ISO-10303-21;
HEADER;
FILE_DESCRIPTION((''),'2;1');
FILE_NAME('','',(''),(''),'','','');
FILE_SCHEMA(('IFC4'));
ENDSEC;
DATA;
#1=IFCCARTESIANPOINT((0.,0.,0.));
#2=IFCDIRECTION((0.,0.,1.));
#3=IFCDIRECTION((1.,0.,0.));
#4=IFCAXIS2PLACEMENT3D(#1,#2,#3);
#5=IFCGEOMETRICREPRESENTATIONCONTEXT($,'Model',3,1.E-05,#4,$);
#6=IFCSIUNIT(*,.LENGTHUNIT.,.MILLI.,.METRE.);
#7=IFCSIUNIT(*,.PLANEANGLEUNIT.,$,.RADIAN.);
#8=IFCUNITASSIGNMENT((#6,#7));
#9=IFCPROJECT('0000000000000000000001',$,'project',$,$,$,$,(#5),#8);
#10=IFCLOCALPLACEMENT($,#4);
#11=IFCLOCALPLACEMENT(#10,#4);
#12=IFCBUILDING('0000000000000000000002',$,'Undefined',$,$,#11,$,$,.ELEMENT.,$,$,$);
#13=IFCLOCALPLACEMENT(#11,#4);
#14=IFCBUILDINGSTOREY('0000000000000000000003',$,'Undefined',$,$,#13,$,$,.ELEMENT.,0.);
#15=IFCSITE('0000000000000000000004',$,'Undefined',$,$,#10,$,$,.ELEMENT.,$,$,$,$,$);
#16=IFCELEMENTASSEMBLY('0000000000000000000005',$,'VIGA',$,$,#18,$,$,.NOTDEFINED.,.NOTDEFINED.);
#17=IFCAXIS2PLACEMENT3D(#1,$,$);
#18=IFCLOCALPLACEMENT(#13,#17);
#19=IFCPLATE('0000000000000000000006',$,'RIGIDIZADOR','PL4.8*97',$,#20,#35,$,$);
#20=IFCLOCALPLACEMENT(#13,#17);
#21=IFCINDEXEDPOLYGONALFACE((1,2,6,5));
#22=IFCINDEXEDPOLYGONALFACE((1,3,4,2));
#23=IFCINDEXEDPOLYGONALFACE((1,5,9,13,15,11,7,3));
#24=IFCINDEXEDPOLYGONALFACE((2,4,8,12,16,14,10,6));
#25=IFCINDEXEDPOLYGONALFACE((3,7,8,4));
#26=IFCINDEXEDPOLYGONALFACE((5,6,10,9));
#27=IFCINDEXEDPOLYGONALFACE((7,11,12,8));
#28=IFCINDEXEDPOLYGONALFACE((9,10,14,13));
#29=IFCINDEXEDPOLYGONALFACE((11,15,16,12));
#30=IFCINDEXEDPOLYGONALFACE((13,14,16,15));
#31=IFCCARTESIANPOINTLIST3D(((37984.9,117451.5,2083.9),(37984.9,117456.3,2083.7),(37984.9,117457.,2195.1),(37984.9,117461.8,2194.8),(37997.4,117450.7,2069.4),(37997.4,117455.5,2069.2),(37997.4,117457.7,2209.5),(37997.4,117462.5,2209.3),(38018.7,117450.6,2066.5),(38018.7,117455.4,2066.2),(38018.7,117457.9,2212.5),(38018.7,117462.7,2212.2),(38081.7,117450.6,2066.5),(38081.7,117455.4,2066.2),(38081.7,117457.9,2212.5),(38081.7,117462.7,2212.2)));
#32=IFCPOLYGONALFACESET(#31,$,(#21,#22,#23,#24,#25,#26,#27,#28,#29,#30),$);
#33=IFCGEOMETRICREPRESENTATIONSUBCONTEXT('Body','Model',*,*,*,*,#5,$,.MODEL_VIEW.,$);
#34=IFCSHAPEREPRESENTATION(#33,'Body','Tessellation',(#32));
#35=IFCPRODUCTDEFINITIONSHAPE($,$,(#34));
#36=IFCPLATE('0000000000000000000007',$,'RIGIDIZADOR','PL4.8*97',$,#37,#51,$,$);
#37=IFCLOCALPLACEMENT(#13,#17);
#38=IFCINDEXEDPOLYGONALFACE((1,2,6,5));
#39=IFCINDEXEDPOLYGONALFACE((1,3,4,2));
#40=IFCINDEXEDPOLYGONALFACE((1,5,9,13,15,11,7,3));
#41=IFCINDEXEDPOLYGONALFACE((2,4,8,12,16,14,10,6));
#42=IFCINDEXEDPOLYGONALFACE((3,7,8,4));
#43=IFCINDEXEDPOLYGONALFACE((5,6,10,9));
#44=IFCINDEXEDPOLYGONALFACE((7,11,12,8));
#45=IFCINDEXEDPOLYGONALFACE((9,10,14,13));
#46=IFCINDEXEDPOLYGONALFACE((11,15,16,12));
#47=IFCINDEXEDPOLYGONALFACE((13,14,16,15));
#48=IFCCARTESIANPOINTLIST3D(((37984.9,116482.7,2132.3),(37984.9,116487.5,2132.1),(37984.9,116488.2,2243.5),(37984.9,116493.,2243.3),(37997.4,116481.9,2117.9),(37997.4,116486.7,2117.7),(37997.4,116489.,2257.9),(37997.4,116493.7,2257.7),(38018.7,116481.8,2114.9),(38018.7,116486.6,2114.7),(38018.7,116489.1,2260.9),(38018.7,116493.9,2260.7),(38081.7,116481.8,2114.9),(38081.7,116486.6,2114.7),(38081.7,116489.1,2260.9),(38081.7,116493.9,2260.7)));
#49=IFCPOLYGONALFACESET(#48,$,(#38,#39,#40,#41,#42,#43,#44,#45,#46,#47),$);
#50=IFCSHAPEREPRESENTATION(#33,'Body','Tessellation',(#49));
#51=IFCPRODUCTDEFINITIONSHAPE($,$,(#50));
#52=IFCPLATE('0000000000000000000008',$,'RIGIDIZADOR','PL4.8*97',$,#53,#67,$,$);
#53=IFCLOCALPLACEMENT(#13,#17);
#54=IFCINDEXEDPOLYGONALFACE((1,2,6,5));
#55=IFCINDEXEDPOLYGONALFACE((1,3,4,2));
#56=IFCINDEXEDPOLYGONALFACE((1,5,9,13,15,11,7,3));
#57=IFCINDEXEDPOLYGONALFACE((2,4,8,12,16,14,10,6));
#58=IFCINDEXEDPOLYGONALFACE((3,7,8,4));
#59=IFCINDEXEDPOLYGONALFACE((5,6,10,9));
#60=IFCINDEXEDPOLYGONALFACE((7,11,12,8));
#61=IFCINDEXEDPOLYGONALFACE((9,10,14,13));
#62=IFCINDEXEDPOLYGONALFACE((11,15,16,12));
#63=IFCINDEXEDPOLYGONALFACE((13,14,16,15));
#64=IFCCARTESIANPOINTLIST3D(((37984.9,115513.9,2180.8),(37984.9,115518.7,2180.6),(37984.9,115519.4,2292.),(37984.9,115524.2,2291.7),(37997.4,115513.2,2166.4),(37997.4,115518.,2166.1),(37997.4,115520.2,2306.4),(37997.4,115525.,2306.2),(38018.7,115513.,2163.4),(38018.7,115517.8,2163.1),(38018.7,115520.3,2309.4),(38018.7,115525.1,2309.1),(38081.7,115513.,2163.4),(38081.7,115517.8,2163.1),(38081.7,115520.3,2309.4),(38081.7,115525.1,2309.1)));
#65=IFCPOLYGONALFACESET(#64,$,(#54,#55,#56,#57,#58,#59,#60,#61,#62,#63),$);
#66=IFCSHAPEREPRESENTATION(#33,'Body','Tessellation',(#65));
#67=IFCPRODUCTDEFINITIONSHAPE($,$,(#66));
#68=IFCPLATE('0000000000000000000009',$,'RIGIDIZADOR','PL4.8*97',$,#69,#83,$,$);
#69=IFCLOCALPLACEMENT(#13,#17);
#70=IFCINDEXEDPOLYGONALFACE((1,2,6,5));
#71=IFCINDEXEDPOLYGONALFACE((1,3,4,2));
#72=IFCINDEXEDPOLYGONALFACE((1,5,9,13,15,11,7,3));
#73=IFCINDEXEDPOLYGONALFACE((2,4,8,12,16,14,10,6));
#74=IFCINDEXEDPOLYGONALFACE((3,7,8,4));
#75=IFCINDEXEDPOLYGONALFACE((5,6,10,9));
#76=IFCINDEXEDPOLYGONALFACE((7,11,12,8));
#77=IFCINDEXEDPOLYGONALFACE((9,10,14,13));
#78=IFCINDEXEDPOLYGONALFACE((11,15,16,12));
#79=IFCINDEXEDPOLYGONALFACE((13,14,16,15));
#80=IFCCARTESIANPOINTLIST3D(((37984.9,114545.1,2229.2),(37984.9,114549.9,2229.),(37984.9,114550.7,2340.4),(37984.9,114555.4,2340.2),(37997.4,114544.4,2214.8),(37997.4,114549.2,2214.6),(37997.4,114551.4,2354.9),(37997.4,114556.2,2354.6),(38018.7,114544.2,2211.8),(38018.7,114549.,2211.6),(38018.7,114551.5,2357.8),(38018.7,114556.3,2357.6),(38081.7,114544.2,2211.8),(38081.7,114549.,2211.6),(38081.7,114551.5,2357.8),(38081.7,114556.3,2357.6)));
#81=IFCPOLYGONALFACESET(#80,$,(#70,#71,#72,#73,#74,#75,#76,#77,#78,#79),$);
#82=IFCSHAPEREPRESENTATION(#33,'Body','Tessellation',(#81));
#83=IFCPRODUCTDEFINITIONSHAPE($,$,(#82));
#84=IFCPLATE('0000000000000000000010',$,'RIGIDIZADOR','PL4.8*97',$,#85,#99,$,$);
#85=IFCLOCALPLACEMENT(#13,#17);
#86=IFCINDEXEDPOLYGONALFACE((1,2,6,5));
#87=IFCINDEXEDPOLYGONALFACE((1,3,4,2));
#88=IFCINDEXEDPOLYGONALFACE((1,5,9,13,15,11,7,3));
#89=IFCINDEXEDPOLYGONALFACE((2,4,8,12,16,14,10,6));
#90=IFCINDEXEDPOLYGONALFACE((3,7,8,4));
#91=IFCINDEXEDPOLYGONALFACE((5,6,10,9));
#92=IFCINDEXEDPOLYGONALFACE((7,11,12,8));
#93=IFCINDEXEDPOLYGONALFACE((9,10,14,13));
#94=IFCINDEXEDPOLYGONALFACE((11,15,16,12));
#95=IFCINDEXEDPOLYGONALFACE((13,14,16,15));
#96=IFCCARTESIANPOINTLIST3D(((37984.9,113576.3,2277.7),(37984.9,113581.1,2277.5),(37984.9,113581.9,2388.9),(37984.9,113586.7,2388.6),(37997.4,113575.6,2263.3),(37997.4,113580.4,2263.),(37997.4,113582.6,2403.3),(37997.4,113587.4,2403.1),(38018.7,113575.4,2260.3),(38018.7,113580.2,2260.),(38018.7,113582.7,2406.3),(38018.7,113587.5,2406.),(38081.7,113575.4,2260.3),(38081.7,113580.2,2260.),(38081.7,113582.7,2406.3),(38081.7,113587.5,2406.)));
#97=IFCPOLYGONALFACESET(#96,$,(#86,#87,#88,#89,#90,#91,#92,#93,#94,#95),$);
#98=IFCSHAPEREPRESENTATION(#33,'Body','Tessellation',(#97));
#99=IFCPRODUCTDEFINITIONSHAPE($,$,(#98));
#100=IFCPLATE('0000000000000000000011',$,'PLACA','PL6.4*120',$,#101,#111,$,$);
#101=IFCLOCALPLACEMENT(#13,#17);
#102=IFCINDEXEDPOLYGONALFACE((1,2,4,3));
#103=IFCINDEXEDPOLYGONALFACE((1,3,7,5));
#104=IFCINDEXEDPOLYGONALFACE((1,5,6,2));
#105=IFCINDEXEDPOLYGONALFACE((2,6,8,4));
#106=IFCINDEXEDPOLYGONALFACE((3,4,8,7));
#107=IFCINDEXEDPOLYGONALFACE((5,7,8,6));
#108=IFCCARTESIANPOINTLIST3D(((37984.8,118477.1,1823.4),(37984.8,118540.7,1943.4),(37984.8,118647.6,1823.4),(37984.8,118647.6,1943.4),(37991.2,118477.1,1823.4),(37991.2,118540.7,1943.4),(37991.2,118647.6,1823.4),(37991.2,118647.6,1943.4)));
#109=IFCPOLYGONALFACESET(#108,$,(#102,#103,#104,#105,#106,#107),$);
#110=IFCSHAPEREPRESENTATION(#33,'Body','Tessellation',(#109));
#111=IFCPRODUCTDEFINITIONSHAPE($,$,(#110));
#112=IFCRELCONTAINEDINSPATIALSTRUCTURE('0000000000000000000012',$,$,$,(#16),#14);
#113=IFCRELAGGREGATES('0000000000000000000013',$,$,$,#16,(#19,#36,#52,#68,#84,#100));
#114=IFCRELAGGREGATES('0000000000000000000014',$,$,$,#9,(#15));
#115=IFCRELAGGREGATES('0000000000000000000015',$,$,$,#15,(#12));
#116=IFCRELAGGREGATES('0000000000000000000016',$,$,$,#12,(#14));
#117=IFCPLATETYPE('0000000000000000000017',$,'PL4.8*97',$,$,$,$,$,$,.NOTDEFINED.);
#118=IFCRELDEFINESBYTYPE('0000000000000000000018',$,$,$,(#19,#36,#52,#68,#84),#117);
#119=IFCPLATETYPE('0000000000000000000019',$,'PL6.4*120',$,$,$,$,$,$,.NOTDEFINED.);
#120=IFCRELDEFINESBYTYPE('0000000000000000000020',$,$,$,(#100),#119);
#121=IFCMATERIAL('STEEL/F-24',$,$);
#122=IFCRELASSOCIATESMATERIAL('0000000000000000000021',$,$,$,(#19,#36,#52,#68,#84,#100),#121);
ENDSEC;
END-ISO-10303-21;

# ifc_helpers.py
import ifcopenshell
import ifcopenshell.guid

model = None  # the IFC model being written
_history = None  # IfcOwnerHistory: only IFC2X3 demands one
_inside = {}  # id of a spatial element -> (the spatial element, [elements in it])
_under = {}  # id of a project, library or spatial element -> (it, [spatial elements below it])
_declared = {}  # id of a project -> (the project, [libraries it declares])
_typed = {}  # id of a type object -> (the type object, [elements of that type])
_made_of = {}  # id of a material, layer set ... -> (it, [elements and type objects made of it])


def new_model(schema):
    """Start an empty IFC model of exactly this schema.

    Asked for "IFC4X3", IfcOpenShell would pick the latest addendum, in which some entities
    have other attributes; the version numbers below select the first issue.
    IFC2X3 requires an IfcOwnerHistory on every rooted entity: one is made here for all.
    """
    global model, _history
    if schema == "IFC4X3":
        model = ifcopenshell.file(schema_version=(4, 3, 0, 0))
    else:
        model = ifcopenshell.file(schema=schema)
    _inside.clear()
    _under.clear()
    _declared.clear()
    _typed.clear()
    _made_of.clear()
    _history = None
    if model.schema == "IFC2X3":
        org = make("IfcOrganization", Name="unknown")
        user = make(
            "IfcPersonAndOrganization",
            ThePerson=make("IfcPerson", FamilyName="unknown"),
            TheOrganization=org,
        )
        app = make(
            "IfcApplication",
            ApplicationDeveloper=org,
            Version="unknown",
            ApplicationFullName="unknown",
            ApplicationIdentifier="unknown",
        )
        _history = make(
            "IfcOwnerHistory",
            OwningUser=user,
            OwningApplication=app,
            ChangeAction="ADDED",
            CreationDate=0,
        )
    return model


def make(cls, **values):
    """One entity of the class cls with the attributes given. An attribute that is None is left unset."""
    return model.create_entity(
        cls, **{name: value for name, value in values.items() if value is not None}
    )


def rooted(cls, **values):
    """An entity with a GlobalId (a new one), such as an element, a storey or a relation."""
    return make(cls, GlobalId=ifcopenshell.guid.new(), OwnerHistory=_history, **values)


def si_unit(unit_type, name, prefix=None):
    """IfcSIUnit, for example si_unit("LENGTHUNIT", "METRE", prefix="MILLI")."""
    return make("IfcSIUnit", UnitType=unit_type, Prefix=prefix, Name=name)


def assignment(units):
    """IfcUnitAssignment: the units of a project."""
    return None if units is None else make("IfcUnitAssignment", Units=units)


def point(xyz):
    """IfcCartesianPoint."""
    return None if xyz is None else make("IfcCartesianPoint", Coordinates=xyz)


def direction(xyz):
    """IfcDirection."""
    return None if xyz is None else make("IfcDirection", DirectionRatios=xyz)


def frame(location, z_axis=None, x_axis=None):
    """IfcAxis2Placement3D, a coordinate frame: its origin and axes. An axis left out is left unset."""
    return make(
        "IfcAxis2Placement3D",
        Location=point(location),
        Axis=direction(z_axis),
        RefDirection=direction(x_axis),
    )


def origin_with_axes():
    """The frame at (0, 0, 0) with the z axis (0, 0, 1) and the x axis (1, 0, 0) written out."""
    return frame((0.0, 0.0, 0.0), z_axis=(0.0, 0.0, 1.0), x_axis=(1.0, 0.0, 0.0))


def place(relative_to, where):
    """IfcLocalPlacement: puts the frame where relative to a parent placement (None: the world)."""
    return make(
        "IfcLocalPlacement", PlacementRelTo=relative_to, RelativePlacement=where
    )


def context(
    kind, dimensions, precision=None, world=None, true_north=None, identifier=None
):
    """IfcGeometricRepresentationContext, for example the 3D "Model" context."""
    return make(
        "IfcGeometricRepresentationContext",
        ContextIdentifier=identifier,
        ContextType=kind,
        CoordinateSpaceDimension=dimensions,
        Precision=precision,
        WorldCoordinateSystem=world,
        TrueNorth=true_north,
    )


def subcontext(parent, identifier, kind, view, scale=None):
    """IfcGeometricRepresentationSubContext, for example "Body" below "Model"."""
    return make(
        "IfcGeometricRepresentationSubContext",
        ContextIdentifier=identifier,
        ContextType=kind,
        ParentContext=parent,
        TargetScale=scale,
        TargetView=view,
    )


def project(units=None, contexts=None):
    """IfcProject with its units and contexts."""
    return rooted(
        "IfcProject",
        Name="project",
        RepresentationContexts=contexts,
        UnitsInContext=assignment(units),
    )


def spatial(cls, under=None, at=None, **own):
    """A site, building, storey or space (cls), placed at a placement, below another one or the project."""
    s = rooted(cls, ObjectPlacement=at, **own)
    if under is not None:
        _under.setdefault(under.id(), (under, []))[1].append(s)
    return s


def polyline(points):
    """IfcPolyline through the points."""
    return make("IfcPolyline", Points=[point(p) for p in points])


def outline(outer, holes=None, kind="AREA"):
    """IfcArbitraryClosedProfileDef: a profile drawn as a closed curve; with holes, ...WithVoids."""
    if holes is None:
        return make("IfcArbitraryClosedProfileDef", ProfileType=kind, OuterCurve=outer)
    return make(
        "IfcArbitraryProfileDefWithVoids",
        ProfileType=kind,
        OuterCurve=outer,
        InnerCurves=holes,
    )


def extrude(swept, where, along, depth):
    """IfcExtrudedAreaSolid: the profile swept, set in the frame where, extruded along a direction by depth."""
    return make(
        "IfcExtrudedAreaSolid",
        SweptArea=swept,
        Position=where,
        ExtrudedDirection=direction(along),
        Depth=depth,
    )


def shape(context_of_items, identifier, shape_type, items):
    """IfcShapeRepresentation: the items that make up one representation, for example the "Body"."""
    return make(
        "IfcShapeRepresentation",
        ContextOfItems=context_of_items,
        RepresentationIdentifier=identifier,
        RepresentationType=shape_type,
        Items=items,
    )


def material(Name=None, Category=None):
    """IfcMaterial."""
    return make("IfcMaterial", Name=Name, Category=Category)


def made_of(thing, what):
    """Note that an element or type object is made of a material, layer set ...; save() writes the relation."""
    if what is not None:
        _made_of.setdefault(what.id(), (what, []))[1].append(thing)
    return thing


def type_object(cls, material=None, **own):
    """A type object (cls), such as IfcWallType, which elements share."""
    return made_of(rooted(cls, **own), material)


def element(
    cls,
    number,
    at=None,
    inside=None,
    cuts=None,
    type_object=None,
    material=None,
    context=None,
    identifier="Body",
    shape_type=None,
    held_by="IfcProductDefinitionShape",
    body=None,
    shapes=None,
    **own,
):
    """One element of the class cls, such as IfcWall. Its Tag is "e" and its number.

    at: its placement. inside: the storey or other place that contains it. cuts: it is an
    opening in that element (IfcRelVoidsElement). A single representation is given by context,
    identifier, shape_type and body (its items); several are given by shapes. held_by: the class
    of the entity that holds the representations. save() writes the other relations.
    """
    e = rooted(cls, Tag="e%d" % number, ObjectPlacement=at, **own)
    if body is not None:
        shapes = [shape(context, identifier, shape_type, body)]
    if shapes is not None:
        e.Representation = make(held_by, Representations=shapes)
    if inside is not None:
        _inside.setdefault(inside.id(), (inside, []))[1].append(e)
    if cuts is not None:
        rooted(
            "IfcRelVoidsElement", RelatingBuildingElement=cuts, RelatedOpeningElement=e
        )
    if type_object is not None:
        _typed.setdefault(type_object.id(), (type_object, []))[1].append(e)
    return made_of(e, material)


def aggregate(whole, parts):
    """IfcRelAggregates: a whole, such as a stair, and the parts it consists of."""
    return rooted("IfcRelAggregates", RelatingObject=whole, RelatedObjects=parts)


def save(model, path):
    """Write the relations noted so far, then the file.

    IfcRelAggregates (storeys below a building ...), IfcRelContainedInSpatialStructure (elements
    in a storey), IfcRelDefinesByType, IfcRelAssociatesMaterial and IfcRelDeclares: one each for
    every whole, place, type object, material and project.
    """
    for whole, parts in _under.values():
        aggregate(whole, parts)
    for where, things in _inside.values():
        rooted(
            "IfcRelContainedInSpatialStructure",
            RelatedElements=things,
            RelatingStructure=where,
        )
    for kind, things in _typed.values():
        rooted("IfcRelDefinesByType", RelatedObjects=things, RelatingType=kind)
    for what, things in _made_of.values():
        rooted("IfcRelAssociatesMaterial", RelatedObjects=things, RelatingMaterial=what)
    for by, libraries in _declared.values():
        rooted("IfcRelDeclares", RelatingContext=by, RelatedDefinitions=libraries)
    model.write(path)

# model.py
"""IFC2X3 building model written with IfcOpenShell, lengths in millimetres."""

from ifc_helpers import new_model, si_unit, frame, origin_with_axes, place, context, subcontext, project, spatial, polyline, outline, extrude, material, type_object, element, aggregate, save


model = new_model("IFC2X3")

# Units and contexts
model_context = context("Model", 3, precision=1e-05, world=origin_with_axes())
body_context = subcontext(model_context, "Body", "Model", "MODEL_VIEW")
ifc_project = project(units=[si_unit("LENGTHUNIT", "METRE", prefix="MILLI"), si_unit("PLANEANGLEUNIT", "RADIAN")], contexts=[model_context])

# Site, building, storey
site_placement = place(None, origin_with_axes())
site = spatial("IfcSite", under=ifc_project, at=site_placement, Name="Undefined", CompositionType="ELEMENT")
building_placement = place(site_placement, origin_with_axes())
building = spatial("IfcBuilding", under=site, at=building_placement, Name="Undefined", CompositionType="ELEMENT")
storey_placement = place(building_placement, origin_with_axes())
storey = spatial("IfcBuildingStorey", under=building, at=storey_placement, Name="Undefined", CompositionType="ELEMENT", Elevation=0.0)

# Element assembly
assembly_1_placement = place(storey_placement, origin_with_axes())
assembly_1 = element("IfcElementAssembly", 1, at=assembly_1_placement, inside=storey, Name="VIGA", AssemblyPlace="NOTDEFINED", PredefinedType="NOTDEFINED")
ifc_material_1 = material(Name="STEEL/F-24")

# Plates
plate_type_1 = type_object("IfcPlateType", Name="PL4.8*97", PredefinedType="NOTDEFINED")
plate_1_placement = place(assembly_1_placement, frame((38081.7, 117460.3, 2212.4), z_axis=(0.0, -0.998752, 0.04995), x_axis=(-1.0, 0.0, 0.0)))
plate_1 = element("IfcPlate", 2, at=plate_1_placement, type_object=plate_type_1, material=ifc_material_1, Name="RIGIDIZADOR", Description="PL4.8*97", context=body_context, shape_type="SweptSolid", body=[
    extrude(outline(polyline([(0.0, 0.0), (63.0, 0.0), (84.3, 3.0), (96.8, 17.4), (96.8, 128.7), (84.3, 143.2), (63.0, 146.2), (0.0, 146.2), (0.0, 0.0)])), frame((0.0, 0.0, -2.4), z_axis=(0.0, 0.0, 1.0), x_axis=(1.0, 0.0, 0.0)), (0.0, 0.0, 1.0), 4.8),
])
plate_2_placement = place(assembly_1_placement, frame((38081.7, 116491.5, 2260.8), z_axis=(0.0, -0.998752, 0.04995), x_axis=(-1.0, 0.0, 0.0)))
plate_2 = element("IfcPlate", 3, at=plate_2_placement, type_object=plate_type_1, material=ifc_material_1, Name="RIGIDIZADOR", Description="PL4.8*97", context=body_context, shape_type="SweptSolid", body=[
    extrude(outline(polyline([(0.0, 0.0), (63.0, 0.0), (84.3, 3.0), (96.8, 17.4), (96.8, 128.7), (84.3, 143.2), (63.0, 146.2), (0.0, 146.2), (0.0, 0.0)])), frame((0.0, 0.0, -2.4), z_axis=(0.0, 0.0, 1.0), x_axis=(1.0, 0.0, 0.0)), (0.0, 0.0, 1.0), 4.8),
])
plate_3_placement = place(assembly_1_placement, frame((38081.7, 115522.7, 2309.3), z_axis=(0.0, -0.998752, 0.04995), x_axis=(-1.0, 0.0, 0.0)))
plate_3 = element("IfcPlate", 4, at=plate_3_placement, type_object=plate_type_1, material=ifc_material_1, Name="RIGIDIZADOR", Description="PL4.8*97", context=body_context, shape_type="SweptSolid", body=[
    extrude(outline(polyline([(0.0, 0.0), (63.0, 0.0), (84.3, 3.0), (96.8, 17.4), (96.8, 128.7), (84.3, 143.2), (63.0, 146.2), (0.0, 146.2), (0.0, 0.0)])), frame((0.0, 0.0, -2.4), z_axis=(0.0, 0.0, 1.0), x_axis=(1.0, 0.0, 0.0)), (0.0, 0.0, 1.0), 4.8),
])
plate_4_placement = place(assembly_1_placement, frame((38081.7, 114553.9, 2357.7), z_axis=(0.0, -0.998752, 0.04995), x_axis=(-1.0, 0.0, 0.0)))
plate_4 = element("IfcPlate", 5, at=plate_4_placement, type_object=plate_type_1, material=ifc_material_1, Name="RIGIDIZADOR", Description="PL4.8*97", context=body_context, shape_type="SweptSolid", body=[
    extrude(outline(polyline([(0.0, 0.0), (63.0, 0.0), (84.3, 3.0), (96.8, 17.4), (96.8, 128.7), (84.3, 143.2), (63.0, 146.2), (0.0, 146.2), (0.0, 0.0)])), frame((0.0, 0.0, -2.4), z_axis=(0.0, 0.0, 1.0), x_axis=(1.0, 0.0, 0.0)), (0.0, 0.0, 1.0), 4.8),
])
plate_5_placement = place(assembly_1_placement, frame((38081.7, 113585.1, 2406.2), z_axis=(0.0, -0.998752, 0.04995), x_axis=(-1.0, 0.0, 0.0)))
plate_5 = element("IfcPlate", 6, at=plate_5_placement, type_object=plate_type_1, material=ifc_material_1, Name="RIGIDIZADOR", Description="PL4.8*97", context=body_context, shape_type="SweptSolid", body=[
    extrude(outline(polyline([(0.0, 0.0), (63.0, 0.0), (84.3, 3.0), (96.8, 17.4), (96.8, 128.7), (84.3, 143.2), (63.0, 146.2), (0.0, 146.2), (0.0, 0.0)])), frame((0.0, 0.0, -2.4), z_axis=(0.0, 0.0, 1.0), x_axis=(1.0, 0.0, 0.0)), (0.0, 0.0, 1.0), 4.8),
])
plate_type_2 = type_object("IfcPlateType", Name="PL6.4*120", PredefinedType="NOTDEFINED")
plate_6_placement = place(assembly_1_placement, frame((37988.0, 118540.7, 1943.4), z_axis=(-1.0, 0.0, 0.0), x_axis=(0.0, 1.0, 0.0)))
plate_6 = element("IfcPlate", 7, at=plate_6_placement, type_object=plate_type_2, material=ifc_material_1, Name="PLACA", Description="PL6.4*120", context=body_context, shape_type="SweptSolid", body=[
    extrude(outline(polyline([(0.0, 0.0), (106.8, 0.0), (106.8, 120.0), (-63.7, 120.0), (0.0, 0.0)])), frame((0.0, 0.0, -3.2), z_axis=(0.0, 0.0, 1.0), x_axis=(1.0, 0.0, 0.0)), (0.0, 0.0, 1.0), 6.4),
])
aggregate(assembly_1, [plate_1, plate_2, plate_3, plate_4, plate_5, plate_6])

save(model, "model.ifc")
